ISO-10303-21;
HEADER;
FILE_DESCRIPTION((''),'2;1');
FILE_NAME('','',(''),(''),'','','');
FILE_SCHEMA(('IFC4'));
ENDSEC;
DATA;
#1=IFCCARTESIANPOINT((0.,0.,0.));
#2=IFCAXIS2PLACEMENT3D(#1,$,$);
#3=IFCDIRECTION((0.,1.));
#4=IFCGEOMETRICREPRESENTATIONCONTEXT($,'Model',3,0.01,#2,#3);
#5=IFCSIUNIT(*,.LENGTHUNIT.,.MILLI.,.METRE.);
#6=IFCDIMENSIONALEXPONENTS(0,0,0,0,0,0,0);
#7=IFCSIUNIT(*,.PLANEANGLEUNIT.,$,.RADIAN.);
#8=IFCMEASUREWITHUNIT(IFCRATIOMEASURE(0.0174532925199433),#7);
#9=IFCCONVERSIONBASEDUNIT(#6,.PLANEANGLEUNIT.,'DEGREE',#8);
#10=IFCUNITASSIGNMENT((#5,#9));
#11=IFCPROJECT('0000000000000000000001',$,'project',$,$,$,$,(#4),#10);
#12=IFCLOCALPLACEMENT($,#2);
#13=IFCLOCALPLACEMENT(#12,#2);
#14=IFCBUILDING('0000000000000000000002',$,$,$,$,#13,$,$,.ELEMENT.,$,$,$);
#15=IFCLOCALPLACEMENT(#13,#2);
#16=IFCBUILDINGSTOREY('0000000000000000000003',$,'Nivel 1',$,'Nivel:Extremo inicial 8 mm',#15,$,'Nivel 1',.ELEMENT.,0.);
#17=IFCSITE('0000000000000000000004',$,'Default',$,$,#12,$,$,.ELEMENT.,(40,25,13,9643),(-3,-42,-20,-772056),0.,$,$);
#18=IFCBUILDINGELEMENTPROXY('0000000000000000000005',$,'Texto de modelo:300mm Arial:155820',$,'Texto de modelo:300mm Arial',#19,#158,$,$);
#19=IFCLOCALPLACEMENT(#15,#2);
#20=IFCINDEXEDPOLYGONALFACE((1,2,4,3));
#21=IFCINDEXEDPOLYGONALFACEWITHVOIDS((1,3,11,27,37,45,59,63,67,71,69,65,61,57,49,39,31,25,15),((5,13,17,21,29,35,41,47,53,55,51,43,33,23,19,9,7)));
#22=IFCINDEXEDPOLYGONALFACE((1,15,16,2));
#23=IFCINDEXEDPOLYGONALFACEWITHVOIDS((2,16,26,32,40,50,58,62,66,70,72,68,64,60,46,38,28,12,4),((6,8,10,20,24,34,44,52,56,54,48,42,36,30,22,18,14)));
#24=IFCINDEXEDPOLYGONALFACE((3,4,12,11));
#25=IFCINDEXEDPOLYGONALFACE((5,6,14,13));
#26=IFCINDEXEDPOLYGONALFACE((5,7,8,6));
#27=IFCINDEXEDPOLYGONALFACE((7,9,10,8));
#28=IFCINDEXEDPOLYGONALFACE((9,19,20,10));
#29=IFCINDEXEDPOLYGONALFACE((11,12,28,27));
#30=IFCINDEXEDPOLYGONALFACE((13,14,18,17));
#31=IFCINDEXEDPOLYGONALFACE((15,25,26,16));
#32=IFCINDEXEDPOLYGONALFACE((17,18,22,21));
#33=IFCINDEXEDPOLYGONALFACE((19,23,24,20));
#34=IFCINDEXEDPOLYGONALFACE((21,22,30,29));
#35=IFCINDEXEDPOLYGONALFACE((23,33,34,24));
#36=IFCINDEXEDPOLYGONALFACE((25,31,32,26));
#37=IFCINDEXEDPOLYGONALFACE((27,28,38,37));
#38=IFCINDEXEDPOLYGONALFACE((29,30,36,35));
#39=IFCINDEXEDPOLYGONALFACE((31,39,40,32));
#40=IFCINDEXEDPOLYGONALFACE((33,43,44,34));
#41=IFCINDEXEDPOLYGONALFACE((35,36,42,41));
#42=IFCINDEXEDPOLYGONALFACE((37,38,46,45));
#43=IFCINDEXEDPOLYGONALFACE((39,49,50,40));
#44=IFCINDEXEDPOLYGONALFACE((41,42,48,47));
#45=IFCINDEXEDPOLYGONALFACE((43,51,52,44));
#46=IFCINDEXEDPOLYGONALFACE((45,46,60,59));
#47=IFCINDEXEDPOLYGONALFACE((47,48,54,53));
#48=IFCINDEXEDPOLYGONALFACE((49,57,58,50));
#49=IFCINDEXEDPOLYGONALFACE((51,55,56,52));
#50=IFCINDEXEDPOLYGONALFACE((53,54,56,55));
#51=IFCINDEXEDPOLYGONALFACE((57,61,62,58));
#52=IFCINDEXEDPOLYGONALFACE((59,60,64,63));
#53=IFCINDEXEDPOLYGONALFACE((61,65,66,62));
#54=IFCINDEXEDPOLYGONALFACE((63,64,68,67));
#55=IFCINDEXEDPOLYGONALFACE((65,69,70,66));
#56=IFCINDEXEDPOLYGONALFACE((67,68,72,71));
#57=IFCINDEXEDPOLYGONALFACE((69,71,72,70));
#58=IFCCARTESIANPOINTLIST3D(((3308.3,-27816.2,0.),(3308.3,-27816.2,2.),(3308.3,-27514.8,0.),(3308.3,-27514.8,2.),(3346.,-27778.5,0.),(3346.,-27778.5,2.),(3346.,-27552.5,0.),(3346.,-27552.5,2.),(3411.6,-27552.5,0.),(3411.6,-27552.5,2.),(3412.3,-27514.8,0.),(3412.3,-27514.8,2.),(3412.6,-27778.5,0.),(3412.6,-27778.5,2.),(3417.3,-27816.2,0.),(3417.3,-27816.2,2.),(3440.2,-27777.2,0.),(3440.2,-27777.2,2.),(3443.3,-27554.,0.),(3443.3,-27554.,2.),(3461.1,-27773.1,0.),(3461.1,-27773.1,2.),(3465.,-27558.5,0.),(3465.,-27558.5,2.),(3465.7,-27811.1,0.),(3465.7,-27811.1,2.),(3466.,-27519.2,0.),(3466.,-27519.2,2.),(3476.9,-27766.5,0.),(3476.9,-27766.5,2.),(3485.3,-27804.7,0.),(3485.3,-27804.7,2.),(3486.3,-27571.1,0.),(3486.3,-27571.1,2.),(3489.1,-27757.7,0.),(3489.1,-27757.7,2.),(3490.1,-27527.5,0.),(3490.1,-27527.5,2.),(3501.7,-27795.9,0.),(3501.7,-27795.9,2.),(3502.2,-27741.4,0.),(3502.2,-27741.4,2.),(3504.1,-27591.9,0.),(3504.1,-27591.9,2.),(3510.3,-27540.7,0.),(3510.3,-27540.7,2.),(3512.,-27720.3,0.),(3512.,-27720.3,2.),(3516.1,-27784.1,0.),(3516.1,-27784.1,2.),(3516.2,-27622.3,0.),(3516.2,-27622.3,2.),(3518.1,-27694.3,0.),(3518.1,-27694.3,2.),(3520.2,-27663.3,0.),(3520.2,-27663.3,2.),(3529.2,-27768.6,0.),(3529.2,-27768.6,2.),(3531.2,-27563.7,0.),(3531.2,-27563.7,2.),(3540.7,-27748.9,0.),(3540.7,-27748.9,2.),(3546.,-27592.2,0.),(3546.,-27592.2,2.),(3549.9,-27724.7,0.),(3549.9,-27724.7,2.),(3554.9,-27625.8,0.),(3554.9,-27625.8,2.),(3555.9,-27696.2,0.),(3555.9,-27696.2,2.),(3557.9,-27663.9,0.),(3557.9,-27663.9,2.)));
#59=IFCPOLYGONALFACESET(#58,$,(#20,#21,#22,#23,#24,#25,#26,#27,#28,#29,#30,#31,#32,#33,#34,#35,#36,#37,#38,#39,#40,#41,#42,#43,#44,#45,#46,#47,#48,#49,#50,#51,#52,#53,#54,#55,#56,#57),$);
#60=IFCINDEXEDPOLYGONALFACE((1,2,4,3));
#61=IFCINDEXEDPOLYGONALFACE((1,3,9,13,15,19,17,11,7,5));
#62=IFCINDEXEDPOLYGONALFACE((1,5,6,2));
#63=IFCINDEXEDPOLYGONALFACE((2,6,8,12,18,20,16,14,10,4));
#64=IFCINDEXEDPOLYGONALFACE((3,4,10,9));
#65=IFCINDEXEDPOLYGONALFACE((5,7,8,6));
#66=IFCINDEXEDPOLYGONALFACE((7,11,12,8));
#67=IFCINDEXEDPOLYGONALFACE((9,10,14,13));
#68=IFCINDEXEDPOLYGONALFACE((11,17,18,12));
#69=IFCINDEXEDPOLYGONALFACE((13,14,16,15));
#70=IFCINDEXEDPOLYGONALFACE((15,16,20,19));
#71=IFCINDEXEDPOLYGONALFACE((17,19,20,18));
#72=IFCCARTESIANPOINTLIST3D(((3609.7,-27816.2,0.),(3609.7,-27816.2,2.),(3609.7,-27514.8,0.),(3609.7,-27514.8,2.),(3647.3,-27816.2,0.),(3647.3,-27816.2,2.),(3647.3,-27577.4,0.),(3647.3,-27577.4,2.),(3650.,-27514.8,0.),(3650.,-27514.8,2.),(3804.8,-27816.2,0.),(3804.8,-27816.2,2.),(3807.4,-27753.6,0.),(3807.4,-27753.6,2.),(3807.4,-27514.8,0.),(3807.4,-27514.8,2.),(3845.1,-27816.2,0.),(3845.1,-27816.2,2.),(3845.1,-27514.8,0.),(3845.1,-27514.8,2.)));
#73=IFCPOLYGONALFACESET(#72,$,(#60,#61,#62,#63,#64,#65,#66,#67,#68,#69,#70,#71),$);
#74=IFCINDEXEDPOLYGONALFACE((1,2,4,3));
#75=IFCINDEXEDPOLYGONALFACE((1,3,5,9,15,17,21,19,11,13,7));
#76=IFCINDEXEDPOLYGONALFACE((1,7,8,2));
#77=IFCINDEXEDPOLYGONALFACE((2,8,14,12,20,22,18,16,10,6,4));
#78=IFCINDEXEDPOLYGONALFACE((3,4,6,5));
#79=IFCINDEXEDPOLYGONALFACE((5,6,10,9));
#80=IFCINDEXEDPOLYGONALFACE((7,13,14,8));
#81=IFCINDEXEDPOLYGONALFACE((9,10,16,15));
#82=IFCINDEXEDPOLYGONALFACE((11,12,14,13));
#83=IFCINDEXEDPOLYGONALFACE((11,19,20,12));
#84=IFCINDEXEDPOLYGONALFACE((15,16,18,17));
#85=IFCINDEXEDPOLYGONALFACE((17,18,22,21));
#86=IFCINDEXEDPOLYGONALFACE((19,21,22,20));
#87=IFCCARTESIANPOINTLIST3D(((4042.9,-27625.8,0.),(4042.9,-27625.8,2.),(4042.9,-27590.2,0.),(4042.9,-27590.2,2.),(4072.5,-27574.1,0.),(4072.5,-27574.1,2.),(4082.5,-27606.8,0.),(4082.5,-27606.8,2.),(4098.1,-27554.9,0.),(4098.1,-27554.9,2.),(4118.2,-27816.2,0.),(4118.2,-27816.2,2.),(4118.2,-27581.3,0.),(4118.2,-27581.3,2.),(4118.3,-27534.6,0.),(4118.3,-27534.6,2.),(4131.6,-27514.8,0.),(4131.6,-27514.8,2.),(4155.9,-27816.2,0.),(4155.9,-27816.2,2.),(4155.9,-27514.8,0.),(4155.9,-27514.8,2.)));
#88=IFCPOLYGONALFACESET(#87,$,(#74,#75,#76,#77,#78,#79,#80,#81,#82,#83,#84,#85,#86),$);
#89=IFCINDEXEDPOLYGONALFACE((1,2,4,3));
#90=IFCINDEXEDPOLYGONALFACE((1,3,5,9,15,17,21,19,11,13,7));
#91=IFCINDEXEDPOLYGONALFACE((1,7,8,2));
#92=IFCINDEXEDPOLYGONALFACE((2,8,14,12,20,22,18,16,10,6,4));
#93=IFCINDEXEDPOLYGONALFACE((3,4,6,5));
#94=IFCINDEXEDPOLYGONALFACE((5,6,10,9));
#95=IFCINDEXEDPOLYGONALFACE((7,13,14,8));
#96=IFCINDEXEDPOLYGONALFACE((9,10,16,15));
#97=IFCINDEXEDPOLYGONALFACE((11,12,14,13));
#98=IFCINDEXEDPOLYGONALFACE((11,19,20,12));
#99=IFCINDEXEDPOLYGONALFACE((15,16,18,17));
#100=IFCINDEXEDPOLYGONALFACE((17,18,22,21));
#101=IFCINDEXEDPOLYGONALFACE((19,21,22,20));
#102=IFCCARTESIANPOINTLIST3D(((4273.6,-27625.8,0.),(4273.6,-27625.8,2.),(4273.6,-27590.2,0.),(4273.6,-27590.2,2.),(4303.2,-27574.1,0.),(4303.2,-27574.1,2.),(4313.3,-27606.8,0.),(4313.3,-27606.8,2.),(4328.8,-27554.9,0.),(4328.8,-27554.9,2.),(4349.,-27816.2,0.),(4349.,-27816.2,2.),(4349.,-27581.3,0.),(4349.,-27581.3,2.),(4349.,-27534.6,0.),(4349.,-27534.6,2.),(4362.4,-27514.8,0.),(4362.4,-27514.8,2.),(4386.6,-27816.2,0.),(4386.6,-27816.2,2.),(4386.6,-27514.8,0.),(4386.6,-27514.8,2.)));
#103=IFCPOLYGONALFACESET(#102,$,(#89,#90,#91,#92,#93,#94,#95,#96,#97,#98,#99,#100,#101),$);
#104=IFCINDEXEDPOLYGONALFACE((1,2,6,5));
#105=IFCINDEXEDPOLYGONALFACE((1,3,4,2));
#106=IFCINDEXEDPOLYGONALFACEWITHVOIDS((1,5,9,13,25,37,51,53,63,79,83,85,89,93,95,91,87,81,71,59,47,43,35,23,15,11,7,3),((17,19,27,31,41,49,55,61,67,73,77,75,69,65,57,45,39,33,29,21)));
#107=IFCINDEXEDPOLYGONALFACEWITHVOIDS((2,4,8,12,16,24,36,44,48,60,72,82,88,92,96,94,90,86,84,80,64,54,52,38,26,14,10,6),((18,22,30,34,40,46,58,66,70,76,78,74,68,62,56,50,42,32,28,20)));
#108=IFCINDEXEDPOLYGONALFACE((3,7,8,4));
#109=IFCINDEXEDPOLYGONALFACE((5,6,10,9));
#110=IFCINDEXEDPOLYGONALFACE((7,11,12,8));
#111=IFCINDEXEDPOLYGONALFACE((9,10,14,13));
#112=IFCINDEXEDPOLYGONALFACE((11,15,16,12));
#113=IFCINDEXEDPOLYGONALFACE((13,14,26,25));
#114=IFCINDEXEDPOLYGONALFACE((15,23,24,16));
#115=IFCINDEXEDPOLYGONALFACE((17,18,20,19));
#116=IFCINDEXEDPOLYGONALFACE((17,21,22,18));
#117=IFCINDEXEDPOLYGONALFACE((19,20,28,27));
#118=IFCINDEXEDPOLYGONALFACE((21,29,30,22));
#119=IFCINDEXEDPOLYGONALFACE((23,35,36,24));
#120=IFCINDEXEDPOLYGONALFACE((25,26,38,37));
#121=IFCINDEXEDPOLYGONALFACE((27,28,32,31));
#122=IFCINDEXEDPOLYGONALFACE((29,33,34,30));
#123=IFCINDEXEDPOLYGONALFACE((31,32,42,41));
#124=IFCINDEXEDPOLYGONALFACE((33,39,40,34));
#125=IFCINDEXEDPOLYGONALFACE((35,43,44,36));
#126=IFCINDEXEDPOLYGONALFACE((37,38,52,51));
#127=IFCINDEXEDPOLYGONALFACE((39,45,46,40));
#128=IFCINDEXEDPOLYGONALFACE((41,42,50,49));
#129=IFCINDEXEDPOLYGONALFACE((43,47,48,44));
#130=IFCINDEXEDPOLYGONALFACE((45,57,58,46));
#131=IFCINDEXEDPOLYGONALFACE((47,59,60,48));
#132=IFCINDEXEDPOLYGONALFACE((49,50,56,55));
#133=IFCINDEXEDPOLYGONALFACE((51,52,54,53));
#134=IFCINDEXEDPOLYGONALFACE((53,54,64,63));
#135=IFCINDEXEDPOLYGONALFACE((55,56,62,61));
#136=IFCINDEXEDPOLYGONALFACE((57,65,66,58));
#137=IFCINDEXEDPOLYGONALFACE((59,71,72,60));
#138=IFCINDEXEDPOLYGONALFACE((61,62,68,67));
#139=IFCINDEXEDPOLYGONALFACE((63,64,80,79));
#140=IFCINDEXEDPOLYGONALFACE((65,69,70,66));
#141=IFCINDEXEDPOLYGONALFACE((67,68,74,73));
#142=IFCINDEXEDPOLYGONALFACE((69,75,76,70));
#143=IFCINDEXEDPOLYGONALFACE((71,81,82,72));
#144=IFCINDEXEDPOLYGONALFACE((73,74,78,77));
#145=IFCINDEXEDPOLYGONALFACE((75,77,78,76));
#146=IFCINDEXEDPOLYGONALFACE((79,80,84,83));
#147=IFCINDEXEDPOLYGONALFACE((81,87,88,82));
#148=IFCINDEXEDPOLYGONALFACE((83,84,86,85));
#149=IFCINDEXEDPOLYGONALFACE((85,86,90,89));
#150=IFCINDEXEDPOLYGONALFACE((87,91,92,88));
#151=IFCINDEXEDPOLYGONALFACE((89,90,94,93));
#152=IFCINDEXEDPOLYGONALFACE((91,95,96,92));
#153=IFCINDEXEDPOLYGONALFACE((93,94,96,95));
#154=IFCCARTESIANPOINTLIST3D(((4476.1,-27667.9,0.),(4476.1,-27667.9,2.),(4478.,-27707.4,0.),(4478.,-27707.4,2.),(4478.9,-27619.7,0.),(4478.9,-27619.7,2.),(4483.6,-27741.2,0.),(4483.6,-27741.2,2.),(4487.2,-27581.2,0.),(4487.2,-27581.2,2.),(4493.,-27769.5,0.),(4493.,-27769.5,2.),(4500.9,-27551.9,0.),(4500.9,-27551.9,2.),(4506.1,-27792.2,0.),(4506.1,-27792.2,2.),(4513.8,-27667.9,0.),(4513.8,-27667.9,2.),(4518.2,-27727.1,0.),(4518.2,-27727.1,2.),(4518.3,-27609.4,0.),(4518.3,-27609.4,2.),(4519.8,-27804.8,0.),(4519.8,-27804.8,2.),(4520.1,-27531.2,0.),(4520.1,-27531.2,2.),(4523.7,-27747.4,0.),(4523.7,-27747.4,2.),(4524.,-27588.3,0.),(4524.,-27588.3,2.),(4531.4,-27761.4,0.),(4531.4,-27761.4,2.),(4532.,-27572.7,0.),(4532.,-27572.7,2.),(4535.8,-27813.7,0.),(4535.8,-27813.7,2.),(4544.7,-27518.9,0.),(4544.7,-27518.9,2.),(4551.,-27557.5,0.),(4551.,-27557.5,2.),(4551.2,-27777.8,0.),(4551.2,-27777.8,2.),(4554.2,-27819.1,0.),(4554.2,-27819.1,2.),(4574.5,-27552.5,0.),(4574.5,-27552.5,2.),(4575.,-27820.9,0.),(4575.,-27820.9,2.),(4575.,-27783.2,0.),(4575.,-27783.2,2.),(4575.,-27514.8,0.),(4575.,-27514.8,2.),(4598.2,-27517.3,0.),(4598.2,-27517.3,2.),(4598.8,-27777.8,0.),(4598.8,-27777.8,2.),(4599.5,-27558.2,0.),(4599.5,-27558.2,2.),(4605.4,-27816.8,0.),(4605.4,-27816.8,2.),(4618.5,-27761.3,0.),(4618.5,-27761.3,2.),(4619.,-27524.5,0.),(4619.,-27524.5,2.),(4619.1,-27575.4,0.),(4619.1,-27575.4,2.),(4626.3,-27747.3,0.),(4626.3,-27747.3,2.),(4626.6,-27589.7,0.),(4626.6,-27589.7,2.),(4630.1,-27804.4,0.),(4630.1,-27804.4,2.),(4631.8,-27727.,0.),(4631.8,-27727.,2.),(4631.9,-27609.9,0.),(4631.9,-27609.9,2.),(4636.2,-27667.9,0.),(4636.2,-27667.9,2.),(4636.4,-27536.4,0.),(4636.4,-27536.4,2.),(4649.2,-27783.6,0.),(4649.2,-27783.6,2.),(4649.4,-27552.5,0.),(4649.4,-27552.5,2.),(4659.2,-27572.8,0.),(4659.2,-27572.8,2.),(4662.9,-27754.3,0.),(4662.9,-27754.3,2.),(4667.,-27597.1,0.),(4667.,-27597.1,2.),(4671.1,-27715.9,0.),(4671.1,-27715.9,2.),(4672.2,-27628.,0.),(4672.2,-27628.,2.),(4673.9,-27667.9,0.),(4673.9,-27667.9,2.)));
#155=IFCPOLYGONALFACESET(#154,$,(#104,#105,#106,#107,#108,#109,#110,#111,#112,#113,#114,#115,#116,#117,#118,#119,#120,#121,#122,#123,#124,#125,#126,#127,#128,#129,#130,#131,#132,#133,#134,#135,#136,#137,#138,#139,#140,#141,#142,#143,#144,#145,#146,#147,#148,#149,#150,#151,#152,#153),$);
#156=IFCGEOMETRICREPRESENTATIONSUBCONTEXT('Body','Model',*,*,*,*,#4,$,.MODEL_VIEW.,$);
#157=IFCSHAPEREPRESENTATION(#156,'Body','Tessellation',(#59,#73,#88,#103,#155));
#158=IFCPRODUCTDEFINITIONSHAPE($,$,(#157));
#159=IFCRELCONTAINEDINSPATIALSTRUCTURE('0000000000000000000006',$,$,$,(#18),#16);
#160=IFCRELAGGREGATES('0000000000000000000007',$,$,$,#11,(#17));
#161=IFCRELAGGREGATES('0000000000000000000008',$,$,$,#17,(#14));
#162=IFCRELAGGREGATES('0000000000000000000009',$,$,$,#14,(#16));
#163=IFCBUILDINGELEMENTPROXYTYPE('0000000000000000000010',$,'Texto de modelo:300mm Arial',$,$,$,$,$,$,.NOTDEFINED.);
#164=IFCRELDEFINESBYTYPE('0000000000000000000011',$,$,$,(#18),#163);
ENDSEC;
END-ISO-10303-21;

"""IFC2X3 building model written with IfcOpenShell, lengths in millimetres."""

from ifc_helpers import new_model, entity, si_unit, converted_unit, direction, frame, origin, place, context, subcontext, project, spatial, polyline, outline, extrude, type_object, element, save


model = new_model("IFC2X3")

# Units and contexts
model_context = context("Model", 3, precision=0.01, world=origin(), true_north=direction((0.0, 1.0)))
body_context = subcontext(model_context, "Body", "Model", "MODEL_VIEW")
ifc_project = project(units=[si_unit("LENGTHUNIT", "METRE", prefix="MILLI"), converted_unit("PLANEANGLEUNIT", "DEGREE", entity("IfcRatioMeasure", 0.0174532925199433), si_unit("PLANEANGLEUNIT", "RADIAN"), dimensions=[0, 0, 0, 0, 0, 0, 0])], contexts=[model_context])

# Site, building, storey
site_placement = place(None, origin())
site = spatial("IfcSite", under=ifc_project, at=site_placement, Name="Default", CompositionType="ELEMENT", RefLatitude=(40, 25, 13, 9643), RefLongitude=(-3, -42, -20, -772056), RefElevation=0.0)
building_placement = place(site_placement, origin())
building = spatial("IfcBuilding", under=site, at=building_placement, CompositionType="ELEMENT")
storey_placement = place(building_placement, origin())
storey = spatial("IfcBuildingStorey", under=building, at=storey_placement, Name="Nivel 1", ObjectType="Nivel:Extremo inicial 8 mm", LongName="Nivel 1", CompositionType="ELEMENT", Elevation=0.0)

# Building element proxy
building_element_proxy_type_1 = type_object("IfcBuildingElementProxyType", Name="Texto de modelo:300mm Arial", PredefinedType="NOTDEFINED")
proxy_1_placement = place(storey_placement, frame((3308.3, -27820.9, 0.0)))
element("IfcBuildingElementProxy", 1, at=proxy_1_placement, inside=storey, type_object=building_element_proxy_type_1, Name="Texto de modelo:300mm Arial:155820", ObjectType="Texto de modelo:300mm Arial", context=body_context, shape_type="SweptSolid", body=[
    extrude(outline(polyline([(-178.4, -141.0), (-69.4, -141.0), (-21.0, -135.8), (-1.4, -129.5), (15.0, -120.7), (29.4, -108.9), (42.6, -93.4), (54.0, -73.7), (63.2, -49.5), (69.2, -21.0), (71.2, 11.3), (68.2, 49.4), (59.3, 83.0), (44.5, 111.5), (23.7, 134.5), (3.4, 147.7), (-20.6, 156.1), (-74.4, 160.4), (-178.4, 160.4), (-178.4, -141.0)]), holes=[polyline([(-140.7, -103.3), (-140.7, 122.7), (-75.1, 122.7), (-43.3, 121.2), (-21.7, 116.7), (-0.4, 104.1), (17.4, 83.3), (29.5, 53.0), (33.5, 11.9), (31.5, -19.1), (25.3, -45.1), (15.5, -66.2), (2.4, -82.5), (-9.8, -91.3), (-25.6, -97.9), (-46.5, -101.9), (-74.1, -103.3), (-140.7, -103.3)])]), frame((178.4, 145.7, 0.0)), (0.0, 0.0, 1.0), 2.0),
    extrude(outline(polyline([(-117.7, -150.7), (-80.1, -150.7), (-80.1, 88.1), (77.4, -150.7), (117.7, -150.7), (117.7, 150.7), (80.1, 150.7), (80.1, -88.1), (-77.4, 150.7), (-117.7, 150.7), (-117.7, -150.7)])), frame((419.1, 155.4, 0.0)), (0.0, 0.0, 1.0), 2.0),
    extrude(outline(polyline([(-204.4, -52.5), (97.0, -52.5), (97.0, -28.2), (77.2, -14.9), (56.9, 5.3), (37.7, 30.9), (21.6, 60.5), (-14.0, 60.5), (5.0, 20.8), (30.4, -14.9), (-204.4, -14.9), (-204.4, -52.5)])), frame((795.1, 209.1, 0.0), z_axis=(0.0, 0.0, 1.0), x_axis=(0.0, 1.0, 0.0)), (0.0, 0.0, 1.0), 2.0),
    extrude(outline(polyline([(-204.4, -52.5), (97.0, -52.5), (97.0, -28.2), (77.2, -14.9), (56.9, 5.3), (37.7, 30.9), (21.6, 60.5), (-14.0, 60.5), (5.0, 20.8), (30.4, -14.9), (-204.4, -14.9), (-204.4, -52.5)])), frame((1025.8, 209.1, 0.0), z_axis=(0.0, 0.0, 1.0), x_axis=(0.0, 1.0, 0.0)), (0.0, 0.0, 1.0), 2.0),
    extrude(outline(polyline([(-5.6, -99.5), (33.9, -99.5), (68.0, -95.5), (96.7, -87.5), (120.0, -75.5), (133.2, -62.4), (142.9, -46.8), (149.1, -28.7), (151.9, -8.0), (149.2, 22.6), (138.0, 47.8), (118.2, 67.9), (89.5, 82.9), (51.6, 93.0), (3.8, 98.0), (-36.2, 98.2), (-67.3, 94.5), (-91.9, 87.9), (-112.6, 79.0), (-129.4, 66.8), (-142.0, 50.0), (-150.3, 29.6), (-153.8, 6.5), (-151.2, -23.9), (-140.1, -49.1), (-120.3, -69.2), (-91.7, -84.4), (-53.6, -94.5), (-5.6, -99.5)]), holes=[polyline([(-3.9, -61.9), (-62.1, -54.6), (-82.9, -47.9), (-98.1, -39.2), (-112.3, -19.5), (-116.2, 4.3), (-109.3, 28.9), (-91.2, 47.7), (-76.5, 54.5), (-56.1, 58.9), (1.9, 60.4), (60.8, 53.2), (80.8, 46.7), (94.5, 38.3), (109.9, 17.8), (114.3, -6.3), (107.7, -29.8), (90.4, -48.7), (76.0, -55.8), (55.5, -60.3), (-3.9, -61.9)])]), frame((1267.5, 152.1, 0.0), z_axis=(0.0, 0.0, 1.0), x_axis=(0.047515, -0.998871, 0.0)), (0.0, 0.0, 1.0), 2.0),
])

save(model, "model.ifc")
